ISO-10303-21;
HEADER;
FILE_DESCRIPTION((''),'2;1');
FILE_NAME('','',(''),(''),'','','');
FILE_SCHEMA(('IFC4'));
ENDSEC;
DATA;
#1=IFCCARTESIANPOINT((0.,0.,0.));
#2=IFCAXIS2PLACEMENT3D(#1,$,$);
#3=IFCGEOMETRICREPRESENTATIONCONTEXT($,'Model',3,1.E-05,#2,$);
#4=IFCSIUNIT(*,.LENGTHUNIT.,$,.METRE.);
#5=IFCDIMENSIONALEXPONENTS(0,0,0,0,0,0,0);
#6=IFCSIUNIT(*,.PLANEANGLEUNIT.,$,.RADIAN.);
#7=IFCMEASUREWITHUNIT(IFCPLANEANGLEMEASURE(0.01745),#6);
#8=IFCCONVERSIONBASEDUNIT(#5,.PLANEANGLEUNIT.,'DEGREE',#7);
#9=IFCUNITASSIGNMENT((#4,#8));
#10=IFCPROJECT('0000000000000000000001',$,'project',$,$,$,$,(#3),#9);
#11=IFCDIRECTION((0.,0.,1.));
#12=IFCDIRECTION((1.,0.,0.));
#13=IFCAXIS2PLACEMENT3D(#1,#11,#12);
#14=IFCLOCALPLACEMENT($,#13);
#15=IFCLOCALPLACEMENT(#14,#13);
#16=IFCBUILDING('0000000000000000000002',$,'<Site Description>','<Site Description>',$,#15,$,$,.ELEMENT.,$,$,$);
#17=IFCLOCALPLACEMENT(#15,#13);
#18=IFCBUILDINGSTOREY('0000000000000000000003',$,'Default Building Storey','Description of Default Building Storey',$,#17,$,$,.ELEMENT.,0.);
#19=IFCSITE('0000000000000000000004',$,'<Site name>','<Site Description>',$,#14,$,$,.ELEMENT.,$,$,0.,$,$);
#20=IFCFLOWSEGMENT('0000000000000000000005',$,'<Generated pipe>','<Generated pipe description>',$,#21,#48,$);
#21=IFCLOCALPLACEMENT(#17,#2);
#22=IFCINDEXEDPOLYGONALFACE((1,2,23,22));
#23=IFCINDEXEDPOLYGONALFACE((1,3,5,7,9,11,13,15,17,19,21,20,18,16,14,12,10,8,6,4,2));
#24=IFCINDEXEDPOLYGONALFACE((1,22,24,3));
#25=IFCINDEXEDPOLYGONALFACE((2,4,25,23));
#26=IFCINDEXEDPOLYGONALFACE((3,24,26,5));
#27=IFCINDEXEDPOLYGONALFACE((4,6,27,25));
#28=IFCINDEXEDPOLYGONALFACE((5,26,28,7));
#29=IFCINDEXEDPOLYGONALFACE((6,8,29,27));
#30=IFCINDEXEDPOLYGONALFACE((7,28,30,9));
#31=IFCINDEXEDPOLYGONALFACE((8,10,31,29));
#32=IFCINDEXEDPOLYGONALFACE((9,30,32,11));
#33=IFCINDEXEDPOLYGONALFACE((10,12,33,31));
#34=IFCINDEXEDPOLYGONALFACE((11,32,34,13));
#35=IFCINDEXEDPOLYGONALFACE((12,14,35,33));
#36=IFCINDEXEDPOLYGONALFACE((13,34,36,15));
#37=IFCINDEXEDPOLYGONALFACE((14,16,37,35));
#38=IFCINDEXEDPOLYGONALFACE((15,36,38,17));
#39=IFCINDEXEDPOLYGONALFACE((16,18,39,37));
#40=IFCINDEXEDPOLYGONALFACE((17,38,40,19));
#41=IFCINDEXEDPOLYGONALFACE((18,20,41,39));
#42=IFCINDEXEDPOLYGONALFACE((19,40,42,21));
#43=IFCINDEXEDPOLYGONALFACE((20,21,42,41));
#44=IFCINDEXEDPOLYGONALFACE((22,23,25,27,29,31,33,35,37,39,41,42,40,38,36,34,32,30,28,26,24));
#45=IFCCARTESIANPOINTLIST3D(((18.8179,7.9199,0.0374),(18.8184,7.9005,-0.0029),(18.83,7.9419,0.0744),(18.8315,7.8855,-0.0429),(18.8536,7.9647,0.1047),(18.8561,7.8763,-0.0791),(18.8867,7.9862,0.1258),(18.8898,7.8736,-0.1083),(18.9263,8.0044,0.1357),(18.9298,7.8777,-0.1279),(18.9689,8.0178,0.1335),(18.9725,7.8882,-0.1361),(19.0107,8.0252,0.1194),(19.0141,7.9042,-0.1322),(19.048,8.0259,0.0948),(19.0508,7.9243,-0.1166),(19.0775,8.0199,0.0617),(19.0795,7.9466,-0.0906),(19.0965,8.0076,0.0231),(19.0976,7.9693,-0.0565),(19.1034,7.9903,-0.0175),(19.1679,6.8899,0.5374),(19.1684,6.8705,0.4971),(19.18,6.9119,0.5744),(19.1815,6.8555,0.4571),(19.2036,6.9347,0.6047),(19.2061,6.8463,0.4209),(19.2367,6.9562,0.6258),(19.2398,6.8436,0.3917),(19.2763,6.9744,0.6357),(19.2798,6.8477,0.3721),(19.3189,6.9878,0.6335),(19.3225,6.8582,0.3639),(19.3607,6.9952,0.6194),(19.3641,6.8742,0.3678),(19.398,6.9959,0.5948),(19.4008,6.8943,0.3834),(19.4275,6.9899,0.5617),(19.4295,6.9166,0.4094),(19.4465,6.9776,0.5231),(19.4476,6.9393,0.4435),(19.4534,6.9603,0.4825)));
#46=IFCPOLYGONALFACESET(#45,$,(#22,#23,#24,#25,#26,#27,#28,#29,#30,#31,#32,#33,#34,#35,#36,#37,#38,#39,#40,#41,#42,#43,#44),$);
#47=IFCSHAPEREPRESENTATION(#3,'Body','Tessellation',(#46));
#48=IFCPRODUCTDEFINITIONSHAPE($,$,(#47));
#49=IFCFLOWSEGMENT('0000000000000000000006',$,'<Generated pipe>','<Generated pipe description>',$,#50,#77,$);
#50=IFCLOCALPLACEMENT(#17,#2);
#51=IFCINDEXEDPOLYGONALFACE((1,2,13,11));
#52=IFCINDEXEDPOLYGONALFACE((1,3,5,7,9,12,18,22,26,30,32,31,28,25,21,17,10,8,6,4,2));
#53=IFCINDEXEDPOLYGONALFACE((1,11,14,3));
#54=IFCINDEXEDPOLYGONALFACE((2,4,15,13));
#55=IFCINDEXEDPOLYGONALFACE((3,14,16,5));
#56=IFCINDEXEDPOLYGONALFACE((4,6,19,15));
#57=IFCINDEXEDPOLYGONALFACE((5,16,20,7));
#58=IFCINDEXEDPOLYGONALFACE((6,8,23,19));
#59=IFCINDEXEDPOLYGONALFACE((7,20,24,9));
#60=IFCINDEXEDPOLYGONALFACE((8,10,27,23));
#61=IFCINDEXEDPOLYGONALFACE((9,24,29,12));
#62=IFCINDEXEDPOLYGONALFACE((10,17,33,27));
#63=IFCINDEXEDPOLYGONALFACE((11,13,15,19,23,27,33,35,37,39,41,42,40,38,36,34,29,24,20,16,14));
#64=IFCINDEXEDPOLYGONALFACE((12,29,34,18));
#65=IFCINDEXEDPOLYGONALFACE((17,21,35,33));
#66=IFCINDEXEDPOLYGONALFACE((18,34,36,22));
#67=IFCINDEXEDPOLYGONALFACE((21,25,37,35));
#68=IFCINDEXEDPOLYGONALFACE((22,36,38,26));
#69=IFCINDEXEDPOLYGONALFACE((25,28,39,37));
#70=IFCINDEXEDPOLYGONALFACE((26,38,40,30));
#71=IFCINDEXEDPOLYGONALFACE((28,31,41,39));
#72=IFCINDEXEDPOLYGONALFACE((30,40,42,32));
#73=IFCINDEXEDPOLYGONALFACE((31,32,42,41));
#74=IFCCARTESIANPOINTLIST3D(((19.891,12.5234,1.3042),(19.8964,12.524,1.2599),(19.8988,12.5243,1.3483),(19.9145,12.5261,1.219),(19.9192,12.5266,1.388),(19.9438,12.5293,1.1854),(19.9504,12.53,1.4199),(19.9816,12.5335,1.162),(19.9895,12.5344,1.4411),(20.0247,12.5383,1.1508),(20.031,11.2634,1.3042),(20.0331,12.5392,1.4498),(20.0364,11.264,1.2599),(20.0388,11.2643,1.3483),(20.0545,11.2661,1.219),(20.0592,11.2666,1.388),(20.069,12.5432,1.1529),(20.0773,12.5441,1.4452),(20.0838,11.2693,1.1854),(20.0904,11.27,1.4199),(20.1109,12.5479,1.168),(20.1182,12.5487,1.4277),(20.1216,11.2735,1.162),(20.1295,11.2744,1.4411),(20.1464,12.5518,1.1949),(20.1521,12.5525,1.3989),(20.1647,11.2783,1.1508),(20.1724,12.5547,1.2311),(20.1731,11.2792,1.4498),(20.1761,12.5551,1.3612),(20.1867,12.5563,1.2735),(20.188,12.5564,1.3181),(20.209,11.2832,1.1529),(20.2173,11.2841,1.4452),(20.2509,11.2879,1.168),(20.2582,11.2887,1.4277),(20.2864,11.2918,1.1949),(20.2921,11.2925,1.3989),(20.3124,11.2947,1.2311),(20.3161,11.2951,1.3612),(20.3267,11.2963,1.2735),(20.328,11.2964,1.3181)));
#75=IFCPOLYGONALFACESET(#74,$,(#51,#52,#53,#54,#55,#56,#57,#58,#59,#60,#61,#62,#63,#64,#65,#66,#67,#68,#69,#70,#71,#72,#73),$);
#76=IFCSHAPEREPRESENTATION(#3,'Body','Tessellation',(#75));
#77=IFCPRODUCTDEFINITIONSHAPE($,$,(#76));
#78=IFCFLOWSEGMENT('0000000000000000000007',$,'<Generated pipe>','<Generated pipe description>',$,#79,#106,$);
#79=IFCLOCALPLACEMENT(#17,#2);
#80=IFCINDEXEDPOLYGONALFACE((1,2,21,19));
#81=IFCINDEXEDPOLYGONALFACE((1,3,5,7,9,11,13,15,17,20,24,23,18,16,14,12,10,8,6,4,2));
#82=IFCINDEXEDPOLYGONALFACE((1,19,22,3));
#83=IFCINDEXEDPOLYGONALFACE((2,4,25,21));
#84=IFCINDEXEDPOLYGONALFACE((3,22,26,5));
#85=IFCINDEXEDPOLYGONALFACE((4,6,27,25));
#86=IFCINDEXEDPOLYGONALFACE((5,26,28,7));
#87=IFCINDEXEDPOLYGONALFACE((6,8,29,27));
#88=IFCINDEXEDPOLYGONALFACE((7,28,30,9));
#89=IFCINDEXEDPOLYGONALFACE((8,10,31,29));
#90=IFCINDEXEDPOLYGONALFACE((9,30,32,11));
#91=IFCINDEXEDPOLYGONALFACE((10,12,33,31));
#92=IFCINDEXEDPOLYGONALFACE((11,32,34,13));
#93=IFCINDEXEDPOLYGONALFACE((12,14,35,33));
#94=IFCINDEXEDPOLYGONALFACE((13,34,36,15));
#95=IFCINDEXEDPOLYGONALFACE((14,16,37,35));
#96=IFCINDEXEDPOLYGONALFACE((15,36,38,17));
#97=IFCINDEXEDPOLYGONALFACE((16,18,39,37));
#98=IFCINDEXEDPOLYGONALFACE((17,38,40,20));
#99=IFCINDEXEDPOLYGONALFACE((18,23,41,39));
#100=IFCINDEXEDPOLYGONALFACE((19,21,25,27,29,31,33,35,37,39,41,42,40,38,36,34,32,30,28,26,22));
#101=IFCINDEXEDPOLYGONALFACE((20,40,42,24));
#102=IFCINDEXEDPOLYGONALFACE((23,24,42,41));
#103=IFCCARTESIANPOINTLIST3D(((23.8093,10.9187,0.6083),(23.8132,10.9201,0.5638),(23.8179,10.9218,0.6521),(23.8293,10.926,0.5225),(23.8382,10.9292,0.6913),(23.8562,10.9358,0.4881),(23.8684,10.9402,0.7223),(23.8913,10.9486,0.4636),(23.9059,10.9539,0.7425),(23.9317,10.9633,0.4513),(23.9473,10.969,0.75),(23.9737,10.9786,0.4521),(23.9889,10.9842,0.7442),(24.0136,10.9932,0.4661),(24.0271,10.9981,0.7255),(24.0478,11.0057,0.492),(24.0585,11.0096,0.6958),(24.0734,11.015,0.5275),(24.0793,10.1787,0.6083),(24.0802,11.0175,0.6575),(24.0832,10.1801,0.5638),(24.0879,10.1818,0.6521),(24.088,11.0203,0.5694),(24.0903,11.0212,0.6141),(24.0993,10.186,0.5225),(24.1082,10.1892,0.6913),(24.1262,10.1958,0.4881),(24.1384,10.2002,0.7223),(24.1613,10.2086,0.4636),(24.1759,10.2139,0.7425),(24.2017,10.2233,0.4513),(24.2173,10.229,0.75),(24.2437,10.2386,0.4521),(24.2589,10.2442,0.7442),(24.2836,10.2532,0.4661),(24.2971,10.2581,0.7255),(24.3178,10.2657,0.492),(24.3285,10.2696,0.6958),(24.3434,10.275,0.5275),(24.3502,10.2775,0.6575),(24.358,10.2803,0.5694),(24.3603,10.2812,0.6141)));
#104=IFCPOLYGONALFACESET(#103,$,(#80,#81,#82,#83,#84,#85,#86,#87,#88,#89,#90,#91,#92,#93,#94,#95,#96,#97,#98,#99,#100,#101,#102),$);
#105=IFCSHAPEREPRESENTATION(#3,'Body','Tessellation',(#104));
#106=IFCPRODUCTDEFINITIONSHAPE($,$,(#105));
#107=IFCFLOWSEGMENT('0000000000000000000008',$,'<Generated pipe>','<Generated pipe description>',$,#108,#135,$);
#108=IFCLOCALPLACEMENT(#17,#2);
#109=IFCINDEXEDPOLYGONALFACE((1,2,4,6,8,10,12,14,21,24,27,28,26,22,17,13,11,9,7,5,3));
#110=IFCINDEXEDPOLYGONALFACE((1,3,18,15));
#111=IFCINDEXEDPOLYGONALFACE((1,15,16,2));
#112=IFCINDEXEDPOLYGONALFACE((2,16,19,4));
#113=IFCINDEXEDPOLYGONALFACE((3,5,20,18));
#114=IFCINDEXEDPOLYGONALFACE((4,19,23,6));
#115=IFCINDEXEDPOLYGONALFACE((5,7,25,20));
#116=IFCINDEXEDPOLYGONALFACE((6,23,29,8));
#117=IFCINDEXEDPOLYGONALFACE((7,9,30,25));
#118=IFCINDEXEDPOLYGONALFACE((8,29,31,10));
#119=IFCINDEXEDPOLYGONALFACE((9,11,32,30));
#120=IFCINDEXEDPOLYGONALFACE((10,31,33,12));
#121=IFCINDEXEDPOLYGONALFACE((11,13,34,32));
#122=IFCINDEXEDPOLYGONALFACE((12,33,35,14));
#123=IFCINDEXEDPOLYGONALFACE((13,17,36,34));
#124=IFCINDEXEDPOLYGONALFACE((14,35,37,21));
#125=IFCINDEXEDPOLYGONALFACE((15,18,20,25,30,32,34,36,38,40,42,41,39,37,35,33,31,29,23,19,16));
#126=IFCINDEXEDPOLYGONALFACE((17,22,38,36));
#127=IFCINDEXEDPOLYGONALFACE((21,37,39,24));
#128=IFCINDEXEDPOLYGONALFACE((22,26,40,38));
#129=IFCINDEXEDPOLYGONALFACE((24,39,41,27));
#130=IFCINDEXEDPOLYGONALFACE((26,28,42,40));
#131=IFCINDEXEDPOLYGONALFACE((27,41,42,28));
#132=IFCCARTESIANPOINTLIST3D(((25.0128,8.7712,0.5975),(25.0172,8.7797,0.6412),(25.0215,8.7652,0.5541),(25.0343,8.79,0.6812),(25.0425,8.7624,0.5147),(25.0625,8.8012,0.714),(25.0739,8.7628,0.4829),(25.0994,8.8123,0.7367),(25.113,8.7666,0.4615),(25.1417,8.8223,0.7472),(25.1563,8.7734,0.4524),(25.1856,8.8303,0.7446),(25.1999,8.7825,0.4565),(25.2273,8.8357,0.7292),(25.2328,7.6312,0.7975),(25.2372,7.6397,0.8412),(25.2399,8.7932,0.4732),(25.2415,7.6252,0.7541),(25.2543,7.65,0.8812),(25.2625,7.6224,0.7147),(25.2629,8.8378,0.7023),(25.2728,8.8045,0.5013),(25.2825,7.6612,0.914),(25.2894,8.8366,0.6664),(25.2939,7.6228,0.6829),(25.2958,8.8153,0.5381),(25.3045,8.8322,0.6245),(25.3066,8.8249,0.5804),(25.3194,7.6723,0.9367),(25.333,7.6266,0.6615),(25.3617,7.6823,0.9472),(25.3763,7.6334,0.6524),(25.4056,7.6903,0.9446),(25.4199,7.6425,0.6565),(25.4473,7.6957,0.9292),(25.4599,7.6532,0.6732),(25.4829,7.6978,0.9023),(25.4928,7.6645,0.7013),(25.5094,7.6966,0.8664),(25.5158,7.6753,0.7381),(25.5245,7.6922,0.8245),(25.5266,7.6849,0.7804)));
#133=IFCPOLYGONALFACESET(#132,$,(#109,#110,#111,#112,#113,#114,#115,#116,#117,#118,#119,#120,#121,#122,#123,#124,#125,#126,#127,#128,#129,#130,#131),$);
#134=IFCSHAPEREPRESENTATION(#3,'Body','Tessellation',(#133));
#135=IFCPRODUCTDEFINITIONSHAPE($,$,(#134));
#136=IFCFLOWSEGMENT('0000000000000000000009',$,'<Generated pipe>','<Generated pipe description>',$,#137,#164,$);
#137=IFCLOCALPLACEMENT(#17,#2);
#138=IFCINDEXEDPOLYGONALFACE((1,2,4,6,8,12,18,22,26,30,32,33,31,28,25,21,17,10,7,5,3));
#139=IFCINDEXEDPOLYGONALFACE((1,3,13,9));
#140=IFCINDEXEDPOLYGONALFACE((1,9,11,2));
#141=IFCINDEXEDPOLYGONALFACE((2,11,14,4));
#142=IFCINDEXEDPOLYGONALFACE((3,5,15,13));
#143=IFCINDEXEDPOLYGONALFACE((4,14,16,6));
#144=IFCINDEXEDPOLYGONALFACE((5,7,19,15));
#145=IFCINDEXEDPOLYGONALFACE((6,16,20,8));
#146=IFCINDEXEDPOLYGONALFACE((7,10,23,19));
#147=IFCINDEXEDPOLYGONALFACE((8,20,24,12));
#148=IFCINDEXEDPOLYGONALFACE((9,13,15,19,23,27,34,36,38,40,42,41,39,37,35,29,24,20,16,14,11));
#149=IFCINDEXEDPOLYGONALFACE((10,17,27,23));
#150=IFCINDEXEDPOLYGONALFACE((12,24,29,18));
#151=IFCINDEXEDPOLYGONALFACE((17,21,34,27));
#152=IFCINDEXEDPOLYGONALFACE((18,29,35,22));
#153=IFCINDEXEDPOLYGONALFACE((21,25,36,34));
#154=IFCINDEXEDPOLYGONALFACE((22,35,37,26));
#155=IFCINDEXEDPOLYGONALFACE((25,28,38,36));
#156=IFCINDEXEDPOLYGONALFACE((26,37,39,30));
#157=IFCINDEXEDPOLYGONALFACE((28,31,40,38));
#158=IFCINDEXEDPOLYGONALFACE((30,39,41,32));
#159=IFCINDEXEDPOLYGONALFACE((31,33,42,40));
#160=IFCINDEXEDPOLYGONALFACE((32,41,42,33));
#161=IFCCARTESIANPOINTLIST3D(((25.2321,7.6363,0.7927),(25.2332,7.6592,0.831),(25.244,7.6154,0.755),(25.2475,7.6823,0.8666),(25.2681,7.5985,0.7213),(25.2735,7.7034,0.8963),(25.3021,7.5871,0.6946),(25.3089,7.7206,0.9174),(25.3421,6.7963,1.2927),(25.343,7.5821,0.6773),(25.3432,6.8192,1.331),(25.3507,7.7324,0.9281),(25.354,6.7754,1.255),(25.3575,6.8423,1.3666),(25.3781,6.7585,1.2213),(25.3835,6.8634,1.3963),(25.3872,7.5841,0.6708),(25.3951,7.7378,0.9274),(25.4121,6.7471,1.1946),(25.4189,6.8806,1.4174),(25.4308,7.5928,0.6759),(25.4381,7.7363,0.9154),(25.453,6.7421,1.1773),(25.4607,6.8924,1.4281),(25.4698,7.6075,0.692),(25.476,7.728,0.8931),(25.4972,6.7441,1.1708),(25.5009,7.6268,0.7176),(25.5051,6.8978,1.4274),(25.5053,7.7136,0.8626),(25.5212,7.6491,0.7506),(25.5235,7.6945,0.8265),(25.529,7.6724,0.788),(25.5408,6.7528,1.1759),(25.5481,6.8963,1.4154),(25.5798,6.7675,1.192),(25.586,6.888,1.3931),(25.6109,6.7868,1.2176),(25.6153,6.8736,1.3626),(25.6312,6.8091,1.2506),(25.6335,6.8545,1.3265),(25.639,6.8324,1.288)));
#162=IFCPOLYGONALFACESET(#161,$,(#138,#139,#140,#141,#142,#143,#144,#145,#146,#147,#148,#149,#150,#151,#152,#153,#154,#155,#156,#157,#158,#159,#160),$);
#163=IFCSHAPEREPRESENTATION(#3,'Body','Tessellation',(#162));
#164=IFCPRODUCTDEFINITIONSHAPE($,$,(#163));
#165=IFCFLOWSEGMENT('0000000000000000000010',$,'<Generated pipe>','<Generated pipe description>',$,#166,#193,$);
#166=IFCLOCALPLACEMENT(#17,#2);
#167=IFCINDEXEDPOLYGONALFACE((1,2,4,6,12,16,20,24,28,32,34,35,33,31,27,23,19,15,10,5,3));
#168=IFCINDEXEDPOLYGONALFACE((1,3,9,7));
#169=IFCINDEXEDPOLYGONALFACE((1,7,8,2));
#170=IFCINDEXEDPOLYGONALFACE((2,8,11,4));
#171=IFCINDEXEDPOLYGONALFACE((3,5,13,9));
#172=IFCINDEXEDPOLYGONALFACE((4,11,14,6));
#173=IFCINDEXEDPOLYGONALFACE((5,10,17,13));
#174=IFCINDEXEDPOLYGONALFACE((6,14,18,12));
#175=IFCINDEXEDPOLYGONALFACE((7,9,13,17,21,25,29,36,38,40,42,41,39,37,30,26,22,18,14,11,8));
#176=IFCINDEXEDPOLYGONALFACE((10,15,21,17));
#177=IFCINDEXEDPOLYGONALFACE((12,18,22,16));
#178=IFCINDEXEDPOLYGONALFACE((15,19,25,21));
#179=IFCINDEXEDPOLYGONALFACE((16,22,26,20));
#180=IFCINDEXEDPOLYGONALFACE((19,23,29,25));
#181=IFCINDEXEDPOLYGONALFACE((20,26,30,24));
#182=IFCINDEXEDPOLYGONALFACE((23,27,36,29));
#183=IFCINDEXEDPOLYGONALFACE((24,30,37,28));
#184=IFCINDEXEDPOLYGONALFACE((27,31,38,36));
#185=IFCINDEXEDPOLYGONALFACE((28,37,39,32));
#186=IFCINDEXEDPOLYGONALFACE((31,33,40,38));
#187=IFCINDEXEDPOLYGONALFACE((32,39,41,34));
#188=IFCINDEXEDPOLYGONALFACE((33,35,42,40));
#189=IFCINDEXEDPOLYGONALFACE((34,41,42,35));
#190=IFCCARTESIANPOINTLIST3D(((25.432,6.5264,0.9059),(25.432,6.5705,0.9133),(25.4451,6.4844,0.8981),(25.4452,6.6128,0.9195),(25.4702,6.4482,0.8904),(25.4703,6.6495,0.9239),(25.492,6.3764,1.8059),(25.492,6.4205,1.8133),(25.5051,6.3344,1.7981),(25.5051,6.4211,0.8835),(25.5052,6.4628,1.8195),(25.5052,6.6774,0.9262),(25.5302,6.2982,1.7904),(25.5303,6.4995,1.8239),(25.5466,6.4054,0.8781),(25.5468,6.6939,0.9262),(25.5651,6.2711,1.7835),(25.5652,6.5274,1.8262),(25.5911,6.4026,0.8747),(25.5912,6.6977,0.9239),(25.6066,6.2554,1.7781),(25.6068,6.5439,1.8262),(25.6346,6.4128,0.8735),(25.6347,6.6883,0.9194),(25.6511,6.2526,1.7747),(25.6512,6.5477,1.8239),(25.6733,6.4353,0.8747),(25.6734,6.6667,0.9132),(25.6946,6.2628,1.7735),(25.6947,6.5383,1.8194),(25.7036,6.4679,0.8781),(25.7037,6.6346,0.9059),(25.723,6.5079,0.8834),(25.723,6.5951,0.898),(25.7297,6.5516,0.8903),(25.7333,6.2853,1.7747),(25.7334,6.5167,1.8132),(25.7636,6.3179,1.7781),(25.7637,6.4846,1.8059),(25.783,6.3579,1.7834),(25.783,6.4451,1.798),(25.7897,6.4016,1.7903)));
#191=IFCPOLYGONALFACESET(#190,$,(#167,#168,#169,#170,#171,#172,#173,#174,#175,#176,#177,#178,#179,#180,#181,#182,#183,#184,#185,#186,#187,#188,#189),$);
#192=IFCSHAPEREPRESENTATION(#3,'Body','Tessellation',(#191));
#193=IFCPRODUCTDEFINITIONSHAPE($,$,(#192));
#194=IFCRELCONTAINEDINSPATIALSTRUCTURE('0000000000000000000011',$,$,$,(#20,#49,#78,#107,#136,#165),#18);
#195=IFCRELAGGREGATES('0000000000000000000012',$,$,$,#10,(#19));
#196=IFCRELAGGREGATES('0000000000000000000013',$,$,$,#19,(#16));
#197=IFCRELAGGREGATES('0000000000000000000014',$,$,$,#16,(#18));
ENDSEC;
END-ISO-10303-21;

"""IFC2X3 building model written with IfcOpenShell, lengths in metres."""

from ifc_helpers import new_model, entity, si_unit, converted_unit, frame, origin, origin_with_axes, origin_2d_with_axis, place, context, project, spatial, circle, extrude, element, save


model = new_model("IFC2X3")

# Units and contexts
model_context = context("Model", 3, precision=1e-05, world=origin())
ifc_project = project(units=[si_unit("LENGTHUNIT", "METRE"), converted_unit("PLANEANGLEUNIT", "DEGREE", entity("IfcPlaneAngleMeasure", 0.01745), si_unit("PLANEANGLEUNIT", "RADIAN"), dimensions=[0, 0, 0, 0, 0, 0, 0])], contexts=[model_context])

# Site, building, storey
site_placement = place(None, origin_with_axes())
site = spatial("IfcSite", under=ifc_project, at=site_placement, Name="<Site name>", Description="<Site Description>", CompositionType="ELEMENT", RefElevation=0.0)
building_placement = place(site_placement, origin_with_axes())
building = spatial("IfcBuilding", under=site, at=building_placement, Name="<Site Description>", Description="<Site Description>", CompositionType="ELEMENT")
storey_placement = place(building_placement, origin_with_axes())
storey = spatial("IfcBuildingStorey", under=building, at=storey_placement, Name="Default Building Storey", Description="Description of Default Building Storey", CompositionType="ELEMENT", Elevation=0.0)

# Flow segments
flow_segment_1_placement = place(storey_placement, frame((19.31, 6.92, 0.5), z_axis=(-0.292337, 0.860307, -0.417625), x_axis=(0.586914, 0.506188, 0.631907)))
element("IfcFlowSegment", 1, at=flow_segment_1_placement, inside=storey, Name="<Generated pipe>", Description="<Generated pipe description>", context=model_context, shape_type="SweptSolid", body=[
    extrude(circle(Radius=0.15, at=origin_2d_with_axis()), origin_with_axes(), (0.0, 0.0, 1.0), 1.1972),
])
flow_segment_2_placement = place(storey_placement, frame((20.04, 12.54, 1.3), z_axis=(0.110432, -0.993884, 0.0), x_axis=(0.986583, 0.10962, 0.120986)))
element("IfcFlowSegment", 2, at=flow_segment_2_placement, inside=storey, Name="<Generated pipe>", Description="<Generated pipe description>", context=model_context, shape_type="SweptSolid", body=[
    extrude(circle(Radius=0.15, at=origin_2d_with_axis()), origin_with_axes(), (0.0, 0.0, 1.0), 1.2678),
])
flow_segment_3_placement = place(storey_placement, frame((23.95, 10.97, 0.6), z_axis=(0.342762, -0.939422, 0.0), x_axis=(0.723082, 0.263827, 0.638395)))
element("IfcFlowSegment", 3, at=flow_segment_3_placement, inside=storey, Name="<Generated pipe>", Description="<Generated pipe description>", context=model_context, shape_type="SweptSolid", body=[
    extrude(circle(Radius=0.15, at=origin_2d_with_axis()), origin_with_axes(), (0.0, 0.0, 1.0), 0.7877),
])
flow_segment_4_placement = place(storey_placement, frame((25.16, 8.8, 0.6), z_axis=(0.186736, -0.967632, 0.16976), x_axis=(0.448523, 0.237712, 0.86158)))
element("IfcFlowSegment", 4, at=flow_segment_4_placement, inside=storey, Name="<Generated pipe>", Description="<Generated pipe description>", context=model_context, shape_type="SweptSolid", body=[
    extrude(circle(Radius=0.15, at=origin_2d_with_axis()), origin_with_axes(), (0.0, 0.0, 1.0), 1.1781),
])
flow_segment_5_placement = place(storey_placement, frame((25.38, 7.66, 0.8), z_axis=(0.111821, -0.853904, 0.508276), x_axis=(0.387406, 0.508474, 0.769006)))
element("IfcFlowSegment", 5, at=flow_segment_5_placement, inside=storey, Name="<Generated pipe>", Description="<Generated pipe description>", context=model_context, shape_type="SweptSolid", body=[
    extrude(circle(Radius=0.15, at=origin_2d_with_axis()), origin_with_axes(), (0.0, 0.0, 1.0), 0.9837),
])
flow_segment_6_placement = place(storey_placement, frame((25.58, 6.55, 0.9), z_axis=(0.065618, -0.164045, 0.984268), x_axis=(0.622449, 0.777684, 0.088117)))
element("IfcFlowSegment", 6, at=flow_segment_6_placement, inside=storey, Name="<Generated pipe>", Description="<Generated pipe description>", context=model_context, shape_type="SweptSolid", body=[
    extrude(circle(Radius=0.15, at=origin_2d_with_axis()), origin_with_axes(), (0.0, 0.0, 1.0), 0.9144),
])

save(model, "model.ifc")
